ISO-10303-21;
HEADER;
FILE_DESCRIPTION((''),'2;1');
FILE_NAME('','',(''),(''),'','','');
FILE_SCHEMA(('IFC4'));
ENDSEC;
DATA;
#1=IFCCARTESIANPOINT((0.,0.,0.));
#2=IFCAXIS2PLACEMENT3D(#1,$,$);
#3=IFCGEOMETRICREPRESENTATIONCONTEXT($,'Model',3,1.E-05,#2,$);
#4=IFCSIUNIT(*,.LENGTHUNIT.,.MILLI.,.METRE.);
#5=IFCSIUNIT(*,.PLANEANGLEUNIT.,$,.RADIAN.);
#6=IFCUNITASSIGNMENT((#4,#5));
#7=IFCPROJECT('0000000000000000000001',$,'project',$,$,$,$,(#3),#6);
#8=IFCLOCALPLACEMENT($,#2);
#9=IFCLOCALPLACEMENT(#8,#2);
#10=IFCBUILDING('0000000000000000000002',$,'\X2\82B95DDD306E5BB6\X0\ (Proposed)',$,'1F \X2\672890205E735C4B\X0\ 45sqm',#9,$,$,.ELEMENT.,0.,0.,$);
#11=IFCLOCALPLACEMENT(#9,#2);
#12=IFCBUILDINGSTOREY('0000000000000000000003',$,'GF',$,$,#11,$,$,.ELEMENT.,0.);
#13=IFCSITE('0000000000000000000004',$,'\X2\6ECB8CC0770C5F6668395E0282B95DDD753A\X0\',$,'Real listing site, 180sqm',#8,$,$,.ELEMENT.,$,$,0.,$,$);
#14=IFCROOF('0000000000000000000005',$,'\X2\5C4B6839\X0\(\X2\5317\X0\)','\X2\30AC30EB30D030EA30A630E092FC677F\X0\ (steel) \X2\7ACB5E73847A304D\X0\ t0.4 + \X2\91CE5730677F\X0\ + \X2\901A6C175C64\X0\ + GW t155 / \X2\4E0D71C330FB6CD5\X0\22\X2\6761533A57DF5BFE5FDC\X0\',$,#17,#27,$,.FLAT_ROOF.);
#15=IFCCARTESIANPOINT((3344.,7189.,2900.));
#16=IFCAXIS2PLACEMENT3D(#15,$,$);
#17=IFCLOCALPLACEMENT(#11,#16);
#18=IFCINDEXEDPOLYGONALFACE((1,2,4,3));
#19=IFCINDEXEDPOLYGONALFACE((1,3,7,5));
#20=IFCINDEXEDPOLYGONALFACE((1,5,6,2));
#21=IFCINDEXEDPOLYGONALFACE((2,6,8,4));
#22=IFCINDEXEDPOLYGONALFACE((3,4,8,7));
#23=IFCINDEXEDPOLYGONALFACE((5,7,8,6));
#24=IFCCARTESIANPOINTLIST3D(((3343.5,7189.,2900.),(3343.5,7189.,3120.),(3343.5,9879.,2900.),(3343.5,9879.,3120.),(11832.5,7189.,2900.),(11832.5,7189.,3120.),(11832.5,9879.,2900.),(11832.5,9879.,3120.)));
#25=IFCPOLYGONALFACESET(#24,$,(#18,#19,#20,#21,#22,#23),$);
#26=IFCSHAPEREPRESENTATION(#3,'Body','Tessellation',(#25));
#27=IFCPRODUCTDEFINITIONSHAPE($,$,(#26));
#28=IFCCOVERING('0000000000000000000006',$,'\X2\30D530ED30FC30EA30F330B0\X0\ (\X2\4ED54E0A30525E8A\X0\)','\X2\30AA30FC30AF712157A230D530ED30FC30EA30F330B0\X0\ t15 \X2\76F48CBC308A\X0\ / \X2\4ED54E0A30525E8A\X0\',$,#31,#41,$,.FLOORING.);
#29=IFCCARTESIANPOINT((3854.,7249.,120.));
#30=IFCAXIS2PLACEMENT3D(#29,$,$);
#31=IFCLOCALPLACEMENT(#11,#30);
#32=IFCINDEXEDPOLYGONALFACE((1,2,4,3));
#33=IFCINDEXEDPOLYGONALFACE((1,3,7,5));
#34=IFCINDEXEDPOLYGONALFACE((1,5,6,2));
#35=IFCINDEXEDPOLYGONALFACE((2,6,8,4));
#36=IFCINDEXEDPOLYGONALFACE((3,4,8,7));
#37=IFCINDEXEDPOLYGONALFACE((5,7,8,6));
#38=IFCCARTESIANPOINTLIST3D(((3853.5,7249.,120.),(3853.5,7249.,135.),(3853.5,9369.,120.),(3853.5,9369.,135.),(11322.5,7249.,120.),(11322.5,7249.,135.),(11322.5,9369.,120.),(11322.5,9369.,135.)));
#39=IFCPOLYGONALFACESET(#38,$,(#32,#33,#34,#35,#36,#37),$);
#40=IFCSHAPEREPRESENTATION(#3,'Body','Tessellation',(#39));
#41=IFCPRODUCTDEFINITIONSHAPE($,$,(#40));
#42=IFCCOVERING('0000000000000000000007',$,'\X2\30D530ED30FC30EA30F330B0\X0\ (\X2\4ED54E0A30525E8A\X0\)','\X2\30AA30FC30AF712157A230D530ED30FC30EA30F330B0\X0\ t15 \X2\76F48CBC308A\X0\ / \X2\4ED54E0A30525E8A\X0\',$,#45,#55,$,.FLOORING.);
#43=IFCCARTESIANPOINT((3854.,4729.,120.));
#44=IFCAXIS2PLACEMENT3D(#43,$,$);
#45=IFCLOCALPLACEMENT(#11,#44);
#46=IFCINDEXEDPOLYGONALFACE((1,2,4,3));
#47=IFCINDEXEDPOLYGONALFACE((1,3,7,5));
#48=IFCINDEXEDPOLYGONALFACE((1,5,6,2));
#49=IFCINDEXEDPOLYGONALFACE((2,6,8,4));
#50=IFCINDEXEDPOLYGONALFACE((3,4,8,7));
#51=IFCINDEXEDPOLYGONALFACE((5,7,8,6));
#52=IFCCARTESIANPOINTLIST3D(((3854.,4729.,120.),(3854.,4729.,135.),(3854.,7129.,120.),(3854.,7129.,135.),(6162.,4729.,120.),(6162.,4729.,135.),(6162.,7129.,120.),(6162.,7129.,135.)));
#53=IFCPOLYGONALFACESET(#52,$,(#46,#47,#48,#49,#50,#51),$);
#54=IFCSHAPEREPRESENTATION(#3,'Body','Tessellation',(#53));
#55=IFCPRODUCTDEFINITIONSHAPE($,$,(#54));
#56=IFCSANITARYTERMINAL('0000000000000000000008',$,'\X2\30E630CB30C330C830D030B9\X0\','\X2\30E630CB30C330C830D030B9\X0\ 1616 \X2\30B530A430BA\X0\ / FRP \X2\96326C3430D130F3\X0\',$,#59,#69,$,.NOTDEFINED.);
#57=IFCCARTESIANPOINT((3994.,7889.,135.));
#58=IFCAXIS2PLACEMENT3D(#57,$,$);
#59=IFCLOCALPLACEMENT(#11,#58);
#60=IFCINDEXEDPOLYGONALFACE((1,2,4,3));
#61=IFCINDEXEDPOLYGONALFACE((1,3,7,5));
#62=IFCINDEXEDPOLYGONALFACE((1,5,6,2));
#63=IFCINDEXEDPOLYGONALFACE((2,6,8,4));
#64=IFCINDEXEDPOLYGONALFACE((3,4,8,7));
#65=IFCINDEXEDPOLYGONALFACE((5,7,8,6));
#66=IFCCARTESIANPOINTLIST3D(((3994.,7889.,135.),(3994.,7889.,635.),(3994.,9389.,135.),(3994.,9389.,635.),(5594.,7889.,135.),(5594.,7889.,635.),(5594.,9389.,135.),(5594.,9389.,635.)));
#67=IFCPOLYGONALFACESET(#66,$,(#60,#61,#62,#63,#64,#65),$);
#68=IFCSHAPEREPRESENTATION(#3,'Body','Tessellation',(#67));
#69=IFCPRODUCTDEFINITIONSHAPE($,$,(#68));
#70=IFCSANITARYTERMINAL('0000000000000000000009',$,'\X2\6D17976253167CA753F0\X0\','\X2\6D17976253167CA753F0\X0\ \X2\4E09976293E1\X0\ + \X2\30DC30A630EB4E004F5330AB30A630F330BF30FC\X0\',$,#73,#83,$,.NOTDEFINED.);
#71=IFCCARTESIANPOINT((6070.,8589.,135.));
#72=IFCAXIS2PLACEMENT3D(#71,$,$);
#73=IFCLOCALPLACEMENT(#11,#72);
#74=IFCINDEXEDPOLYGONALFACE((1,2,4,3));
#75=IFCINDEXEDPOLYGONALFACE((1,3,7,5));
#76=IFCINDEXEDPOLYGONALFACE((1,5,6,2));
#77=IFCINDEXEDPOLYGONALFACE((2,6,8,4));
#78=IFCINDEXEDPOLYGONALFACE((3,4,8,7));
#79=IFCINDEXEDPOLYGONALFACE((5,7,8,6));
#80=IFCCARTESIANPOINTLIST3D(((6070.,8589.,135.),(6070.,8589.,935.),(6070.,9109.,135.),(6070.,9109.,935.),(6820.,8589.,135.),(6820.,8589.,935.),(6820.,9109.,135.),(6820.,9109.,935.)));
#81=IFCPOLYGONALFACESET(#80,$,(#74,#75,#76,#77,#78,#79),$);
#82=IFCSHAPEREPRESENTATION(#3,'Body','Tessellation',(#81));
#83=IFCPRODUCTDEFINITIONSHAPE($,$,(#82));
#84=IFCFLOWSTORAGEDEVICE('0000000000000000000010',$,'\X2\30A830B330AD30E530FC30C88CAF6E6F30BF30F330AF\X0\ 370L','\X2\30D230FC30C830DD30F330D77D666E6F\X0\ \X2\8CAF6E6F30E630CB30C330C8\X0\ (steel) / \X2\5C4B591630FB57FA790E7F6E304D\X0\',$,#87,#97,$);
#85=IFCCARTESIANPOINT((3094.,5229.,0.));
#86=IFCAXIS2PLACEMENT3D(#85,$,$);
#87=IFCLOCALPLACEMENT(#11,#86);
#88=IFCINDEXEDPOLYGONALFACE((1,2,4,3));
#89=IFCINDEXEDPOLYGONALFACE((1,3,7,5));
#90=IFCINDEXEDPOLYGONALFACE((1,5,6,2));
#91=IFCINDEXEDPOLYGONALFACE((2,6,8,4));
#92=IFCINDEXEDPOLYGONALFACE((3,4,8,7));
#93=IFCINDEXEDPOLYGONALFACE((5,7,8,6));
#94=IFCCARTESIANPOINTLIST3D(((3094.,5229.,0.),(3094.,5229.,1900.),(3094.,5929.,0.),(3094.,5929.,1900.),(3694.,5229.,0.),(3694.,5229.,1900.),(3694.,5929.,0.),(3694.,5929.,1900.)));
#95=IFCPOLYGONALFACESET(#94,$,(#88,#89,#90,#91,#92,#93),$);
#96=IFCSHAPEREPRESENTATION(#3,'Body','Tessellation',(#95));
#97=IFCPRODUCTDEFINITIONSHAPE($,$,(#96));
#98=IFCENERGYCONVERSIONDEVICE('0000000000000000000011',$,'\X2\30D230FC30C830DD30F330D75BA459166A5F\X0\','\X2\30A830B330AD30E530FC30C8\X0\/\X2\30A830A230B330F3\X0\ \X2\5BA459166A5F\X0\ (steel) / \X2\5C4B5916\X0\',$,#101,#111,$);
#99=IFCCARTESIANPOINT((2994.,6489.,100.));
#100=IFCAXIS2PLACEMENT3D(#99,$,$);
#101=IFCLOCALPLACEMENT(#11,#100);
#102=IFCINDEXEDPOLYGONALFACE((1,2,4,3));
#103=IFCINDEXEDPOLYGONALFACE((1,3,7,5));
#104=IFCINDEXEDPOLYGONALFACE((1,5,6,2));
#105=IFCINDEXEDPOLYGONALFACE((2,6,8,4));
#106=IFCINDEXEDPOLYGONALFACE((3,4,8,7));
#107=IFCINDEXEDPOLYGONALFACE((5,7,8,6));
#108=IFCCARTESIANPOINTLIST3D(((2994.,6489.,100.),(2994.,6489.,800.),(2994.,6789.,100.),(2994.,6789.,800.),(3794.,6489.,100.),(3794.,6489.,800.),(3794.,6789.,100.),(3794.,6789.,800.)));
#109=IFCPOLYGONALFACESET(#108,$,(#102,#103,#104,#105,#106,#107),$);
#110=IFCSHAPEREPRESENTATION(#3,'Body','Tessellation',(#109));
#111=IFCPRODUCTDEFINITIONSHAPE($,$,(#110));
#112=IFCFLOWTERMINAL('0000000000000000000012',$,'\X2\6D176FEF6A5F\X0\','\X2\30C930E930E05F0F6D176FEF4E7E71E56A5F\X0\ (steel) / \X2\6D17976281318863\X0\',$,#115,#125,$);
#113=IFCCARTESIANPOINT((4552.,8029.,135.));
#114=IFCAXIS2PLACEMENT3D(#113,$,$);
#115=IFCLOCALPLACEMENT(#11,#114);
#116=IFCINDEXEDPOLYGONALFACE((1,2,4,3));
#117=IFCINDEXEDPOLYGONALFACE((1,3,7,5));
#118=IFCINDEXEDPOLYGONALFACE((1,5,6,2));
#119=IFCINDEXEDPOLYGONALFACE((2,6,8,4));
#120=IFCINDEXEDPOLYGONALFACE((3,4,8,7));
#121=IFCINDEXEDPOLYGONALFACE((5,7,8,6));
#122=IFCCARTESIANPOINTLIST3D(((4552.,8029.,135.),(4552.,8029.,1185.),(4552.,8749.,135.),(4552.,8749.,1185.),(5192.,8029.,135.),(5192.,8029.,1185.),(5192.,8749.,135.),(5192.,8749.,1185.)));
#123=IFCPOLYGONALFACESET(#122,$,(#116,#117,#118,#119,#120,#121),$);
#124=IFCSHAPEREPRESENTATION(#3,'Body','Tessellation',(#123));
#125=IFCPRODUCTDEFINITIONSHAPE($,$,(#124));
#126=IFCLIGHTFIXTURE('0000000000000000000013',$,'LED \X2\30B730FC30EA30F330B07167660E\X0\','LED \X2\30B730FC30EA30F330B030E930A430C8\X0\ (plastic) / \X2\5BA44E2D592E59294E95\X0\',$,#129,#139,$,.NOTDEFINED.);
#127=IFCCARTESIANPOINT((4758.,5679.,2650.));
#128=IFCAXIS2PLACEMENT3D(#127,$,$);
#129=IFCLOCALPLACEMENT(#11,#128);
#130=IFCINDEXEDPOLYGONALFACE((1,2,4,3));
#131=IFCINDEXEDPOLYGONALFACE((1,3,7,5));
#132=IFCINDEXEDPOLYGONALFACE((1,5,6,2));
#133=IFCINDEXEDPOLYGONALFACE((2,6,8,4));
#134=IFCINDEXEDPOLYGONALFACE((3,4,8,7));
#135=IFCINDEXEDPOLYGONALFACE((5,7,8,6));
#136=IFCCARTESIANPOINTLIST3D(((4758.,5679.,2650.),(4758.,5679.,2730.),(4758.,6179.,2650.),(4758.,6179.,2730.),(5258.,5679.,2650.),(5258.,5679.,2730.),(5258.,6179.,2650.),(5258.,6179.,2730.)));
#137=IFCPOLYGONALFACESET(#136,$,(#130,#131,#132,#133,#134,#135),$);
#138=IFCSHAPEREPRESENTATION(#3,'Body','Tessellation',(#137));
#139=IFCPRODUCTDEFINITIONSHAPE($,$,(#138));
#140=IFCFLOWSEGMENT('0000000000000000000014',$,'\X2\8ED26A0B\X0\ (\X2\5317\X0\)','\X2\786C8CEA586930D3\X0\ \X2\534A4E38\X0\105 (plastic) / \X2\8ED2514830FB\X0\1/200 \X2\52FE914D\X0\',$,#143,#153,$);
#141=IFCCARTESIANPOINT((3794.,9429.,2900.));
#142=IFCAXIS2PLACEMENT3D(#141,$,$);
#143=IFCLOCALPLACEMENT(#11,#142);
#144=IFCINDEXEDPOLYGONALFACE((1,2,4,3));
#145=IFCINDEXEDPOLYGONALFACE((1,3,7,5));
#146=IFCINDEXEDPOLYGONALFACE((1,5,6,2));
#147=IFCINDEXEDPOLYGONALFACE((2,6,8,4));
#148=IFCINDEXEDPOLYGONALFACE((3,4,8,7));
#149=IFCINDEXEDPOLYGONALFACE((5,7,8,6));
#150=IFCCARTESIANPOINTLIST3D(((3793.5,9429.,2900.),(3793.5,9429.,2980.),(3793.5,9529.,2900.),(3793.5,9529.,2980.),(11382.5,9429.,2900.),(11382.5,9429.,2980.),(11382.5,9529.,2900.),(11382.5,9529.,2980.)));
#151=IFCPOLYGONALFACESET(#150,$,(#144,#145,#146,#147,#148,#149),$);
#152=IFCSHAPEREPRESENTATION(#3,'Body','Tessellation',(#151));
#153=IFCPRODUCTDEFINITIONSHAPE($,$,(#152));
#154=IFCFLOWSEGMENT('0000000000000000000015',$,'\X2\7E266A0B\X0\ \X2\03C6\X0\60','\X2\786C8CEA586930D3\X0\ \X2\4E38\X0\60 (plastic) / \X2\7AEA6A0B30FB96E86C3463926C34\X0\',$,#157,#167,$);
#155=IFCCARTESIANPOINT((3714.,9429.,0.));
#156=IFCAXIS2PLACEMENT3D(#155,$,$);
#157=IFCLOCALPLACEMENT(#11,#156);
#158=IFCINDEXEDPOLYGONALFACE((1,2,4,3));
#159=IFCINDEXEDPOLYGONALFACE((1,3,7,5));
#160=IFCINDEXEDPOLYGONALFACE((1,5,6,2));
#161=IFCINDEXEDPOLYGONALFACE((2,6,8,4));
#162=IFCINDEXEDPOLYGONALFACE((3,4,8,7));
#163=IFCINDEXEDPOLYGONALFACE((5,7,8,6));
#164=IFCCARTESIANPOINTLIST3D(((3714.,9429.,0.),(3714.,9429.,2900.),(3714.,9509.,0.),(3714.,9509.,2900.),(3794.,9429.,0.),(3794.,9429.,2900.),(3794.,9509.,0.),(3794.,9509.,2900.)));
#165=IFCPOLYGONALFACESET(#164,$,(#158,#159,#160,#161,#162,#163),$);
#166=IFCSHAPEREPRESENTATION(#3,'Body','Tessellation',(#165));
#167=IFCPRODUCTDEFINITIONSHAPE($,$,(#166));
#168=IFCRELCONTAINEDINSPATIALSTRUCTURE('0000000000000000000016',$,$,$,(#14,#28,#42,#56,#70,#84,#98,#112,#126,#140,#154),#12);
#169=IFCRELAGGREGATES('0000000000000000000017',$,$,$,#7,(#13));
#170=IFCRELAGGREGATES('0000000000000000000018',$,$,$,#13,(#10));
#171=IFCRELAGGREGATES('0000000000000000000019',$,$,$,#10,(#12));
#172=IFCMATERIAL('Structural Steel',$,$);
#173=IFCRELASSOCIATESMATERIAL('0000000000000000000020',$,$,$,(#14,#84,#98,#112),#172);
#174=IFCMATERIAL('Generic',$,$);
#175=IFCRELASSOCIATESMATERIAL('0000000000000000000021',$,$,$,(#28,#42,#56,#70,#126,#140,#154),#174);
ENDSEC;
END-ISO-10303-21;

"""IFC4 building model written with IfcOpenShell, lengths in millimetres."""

from ifc_helpers import new_model, si_unit, frame, frame_2d, origin, place, context, project, spatial, rectangle, extrude, material, element, save


model = new_model("IFC4")

# Units and contexts
model_context = context("Model", 3, precision=1e-05, world=origin())
ifc_project = project(units=[si_unit("LENGTHUNIT", "METRE", prefix="MILLI"), si_unit("PLANEANGLEUNIT", "RADIAN")], contexts=[model_context])

# Site, building, storey
site_placement = place(None, origin())
site = spatial("IfcSite", under=ifc_project, at=site_placement, Name="滋賀県彦根市芹川町", ObjectType="Real listing site, 180sqm", CompositionType="ELEMENT", RefElevation=0.0)
building_placement = place(site_placement, origin())
building = spatial("IfcBuilding", under=site, at=building_placement, Name="芹川の家 (Proposed)", ObjectType="1F 木造平屋 45sqm", CompositionType="ELEMENT", ElevationOfRefHeight=0.0, ElevationOfTerrain=0.0)
storey_placement = place(building_placement, origin())
storey = spatial("IfcBuildingStorey", under=building, at=storey_placement, Name="GF", CompositionType="ELEMENT", Elevation=0.0)

# Roof
ifc_material_1 = material(Name="Structural Steel")
roof_placement = place(storey_placement, frame((3344.0, 7189.0, 2900.0)))
element("IfcRoof", 1, at=roof_placement, inside=storey, material=ifc_material_1, Name="屋根(北)", Description="ガルバリウム鋼板 (steel) 立平葺き t0.4 + 野地板 + 通気層 + GW t155 / 不燃・法22条区域対応", PredefinedType="FLAT_ROOF", context=model_context, shape_type="SweptSolid", body=[
    extrude(rectangle(XDim=8489.0, YDim=2690.0, at=frame_2d((4244.0, 1345.0))), frame((3344.0, 7189.0, 2900.0)), (0.0, 0.0, 1.0), 220.0),
])

# Coverings
ifc_material_2 = material(Name="Generic")
covering_1_placement = place(storey_placement, frame((3854.0, 7249.0, 120.0)))
element("IfcCovering", 2, at=covering_1_placement, inside=storey, material=ifc_material_2, Name="フローリング (仕上げ床)", Description="オーク無垢フローリング t15 直貼り / 仕上げ床", PredefinedType="FLOORING", context=model_context, shape_type="SweptSolid", body=[
    extrude(rectangle(XDim=7469.0, YDim=2120.0, at=frame_2d((3734.0, 1060.0))), frame((3854.0, 7249.0, 120.0)), (0.0, 0.0, 1.0), 15.0),
])
covering_2_placement = place(storey_placement, frame((3854.0, 4729.0, 120.0)))
element("IfcCovering", 3, at=covering_2_placement, inside=storey, material=ifc_material_2, Name="フローリング (仕上げ床)", Description="オーク無垢フローリング t15 直貼り / 仕上げ床", PredefinedType="FLOORING", context=model_context, shape_type="SweptSolid", body=[
    extrude(rectangle(XDim=2308.0, YDim=2400.0, at=frame_2d((1154.0, 1200.0))), frame((3854.0, 4729.0, 120.0)), (0.0, 0.0, 1.0), 15.0),
])

# Sanitary terminals
sanitary_terminal_1_placement = place(storey_placement, frame((3994.0, 7889.0, 135.0)))
element("IfcSanitaryTerminal", 4, at=sanitary_terminal_1_placement, inside=storey, material=ifc_material_2, Name="ユニットバス", Description="ユニットバス 1616 サイズ / FRP 防水パン", PredefinedType="NOTDEFINED", context=model_context, shape_type="SweptSolid", body=[
    extrude(rectangle(XDim=1600.0, YDim=1500.0, at=frame_2d((800.0, 750.0))), frame((3994.0, 7889.0, 135.0)), (0.0, 0.0, 1.0), 500.0),
])
sanitary_terminal_2_placement = place(storey_placement, frame((6070.0, 8589.0, 135.0)))
element("IfcSanitaryTerminal", 5, at=sanitary_terminal_2_placement, inside=storey, material=ifc_material_2, Name="洗面化粧台", Description="洗面化粧台 三面鏡 + ボウル一体カウンター", PredefinedType="NOTDEFINED", context=model_context, shape_type="SweptSolid", body=[
    extrude(rectangle(XDim=750.0, YDim=520.0, at=frame_2d((375.0, 260.0))), frame((6070.0, 8589.0, 135.0)), (0.0, 0.0, 1.0), 800.0),
])

# Flow storage device
flow_storage_device_placement = place(storey_placement, frame((3094.0, 5229.0, 0.0)))
element("IfcFlowStorageDevice", 6, at=flow_storage_device_placement, inside=storey, material=ifc_material_1, Name="エコキュート貯湯タンク 370L", Description="ヒートポンプ給湯 貯湯ユニット (steel) / 屋外・基礎置き", context=model_context, shape_type="SweptSolid", body=[
    extrude(rectangle(XDim=600.0, YDim=700.0, at=frame_2d((300.0, 350.0))), frame((3094.0, 5229.0, 0.0)), (0.0, 0.0, 1.0), 1900.0),
])

# Energy conversion device
energy_conversion_device_placement = place(storey_placement, frame((2994.0, 6489.0, 100.0)))
element("IfcEnergyConversionDevice", 7, at=energy_conversion_device_placement, inside=storey, material=ifc_material_1, Name="ヒートポンプ室外機", Description="エコキュート/エアコン 室外機 (steel) / 屋外", context=model_context, shape_type="SweptSolid", body=[
    extrude(rectangle(XDim=800.0, YDim=300.0, at=frame_2d((400.0, 150.0))), frame((2994.0, 6489.0, 100.0)), (0.0, 0.0, 1.0), 700.0),
])

# Flow terminal
flow_terminal_placement = place(storey_placement, frame((4552.0, 8029.0, 135.0)))
element("IfcFlowTerminal", 8, at=flow_terminal_placement, inside=storey, material=ifc_material_1, Name="洗濯機", Description="ドラム式洗濯乾燥機 (steel) / 洗面脱衣", context=model_context, shape_type="SweptSolid", body=[
    extrude(rectangle(XDim=640.0, YDim=720.0, at=frame_2d((320.0, 360.0))), frame((4552.0, 8029.0, 135.0)), (0.0, 0.0, 1.0), 1050.0),
])

# Light fixture
light_fixture_placement = place(storey_placement, frame((4758.0, 5679.0, 2650.0)))
element("IfcLightFixture", 9, at=light_fixture_placement, inside=storey, material=ifc_material_2, Name="LED シーリング照明", Description="LED シーリングライト (plastic) / 室中央天井", PredefinedType="NOTDEFINED", context=model_context, shape_type="SweptSolid", body=[
    extrude(rectangle(XDim=500.0, YDim=500.0, at=frame_2d((250.0, 250.0))), frame((4758.0, 5679.0, 2650.0)), (0.0, 0.0, 1.0), 80.0),
])

# Flow segments
flow_segment_1_placement = place(storey_placement, frame((3794.0, 9429.0, 2900.0)))
element("IfcFlowSegment", 10, at=flow_segment_1_placement, inside=storey, material=ifc_material_2, Name="軒樋 (北)", Description="硬質塩ビ 半丸105 (plastic) / 軒先・1/200 勾配", context=model_context, shape_type="SweptSolid", body=[
    extrude(rectangle(XDim=7589.0, YDim=100.0, at=frame_2d((3794.0, 50.0))), frame((3794.0, 9429.0, 2900.0)), (0.0, 0.0, 1.0), 80.0),
])
flow_segment_2_placement = place(storey_placement, frame((3714.0, 9429.0, 0.0)))
element("IfcFlowSegment", 11, at=flow_segment_2_placement, inside=storey, material=ifc_material_2, Name="縦樋 φ60", Description="硬質塩ビ 丸60 (plastic) / 竪樋・雨水排水", context=model_context, shape_type="SweptSolid", body=[
    extrude(rectangle(XDim=80.0, YDim=80.0, at=frame_2d((40.0, 40.0))), frame((3714.0, 9429.0, 0.0)), (0.0, 0.0, 1.0), 2900.0),
])

save(model, "model.ifc")
